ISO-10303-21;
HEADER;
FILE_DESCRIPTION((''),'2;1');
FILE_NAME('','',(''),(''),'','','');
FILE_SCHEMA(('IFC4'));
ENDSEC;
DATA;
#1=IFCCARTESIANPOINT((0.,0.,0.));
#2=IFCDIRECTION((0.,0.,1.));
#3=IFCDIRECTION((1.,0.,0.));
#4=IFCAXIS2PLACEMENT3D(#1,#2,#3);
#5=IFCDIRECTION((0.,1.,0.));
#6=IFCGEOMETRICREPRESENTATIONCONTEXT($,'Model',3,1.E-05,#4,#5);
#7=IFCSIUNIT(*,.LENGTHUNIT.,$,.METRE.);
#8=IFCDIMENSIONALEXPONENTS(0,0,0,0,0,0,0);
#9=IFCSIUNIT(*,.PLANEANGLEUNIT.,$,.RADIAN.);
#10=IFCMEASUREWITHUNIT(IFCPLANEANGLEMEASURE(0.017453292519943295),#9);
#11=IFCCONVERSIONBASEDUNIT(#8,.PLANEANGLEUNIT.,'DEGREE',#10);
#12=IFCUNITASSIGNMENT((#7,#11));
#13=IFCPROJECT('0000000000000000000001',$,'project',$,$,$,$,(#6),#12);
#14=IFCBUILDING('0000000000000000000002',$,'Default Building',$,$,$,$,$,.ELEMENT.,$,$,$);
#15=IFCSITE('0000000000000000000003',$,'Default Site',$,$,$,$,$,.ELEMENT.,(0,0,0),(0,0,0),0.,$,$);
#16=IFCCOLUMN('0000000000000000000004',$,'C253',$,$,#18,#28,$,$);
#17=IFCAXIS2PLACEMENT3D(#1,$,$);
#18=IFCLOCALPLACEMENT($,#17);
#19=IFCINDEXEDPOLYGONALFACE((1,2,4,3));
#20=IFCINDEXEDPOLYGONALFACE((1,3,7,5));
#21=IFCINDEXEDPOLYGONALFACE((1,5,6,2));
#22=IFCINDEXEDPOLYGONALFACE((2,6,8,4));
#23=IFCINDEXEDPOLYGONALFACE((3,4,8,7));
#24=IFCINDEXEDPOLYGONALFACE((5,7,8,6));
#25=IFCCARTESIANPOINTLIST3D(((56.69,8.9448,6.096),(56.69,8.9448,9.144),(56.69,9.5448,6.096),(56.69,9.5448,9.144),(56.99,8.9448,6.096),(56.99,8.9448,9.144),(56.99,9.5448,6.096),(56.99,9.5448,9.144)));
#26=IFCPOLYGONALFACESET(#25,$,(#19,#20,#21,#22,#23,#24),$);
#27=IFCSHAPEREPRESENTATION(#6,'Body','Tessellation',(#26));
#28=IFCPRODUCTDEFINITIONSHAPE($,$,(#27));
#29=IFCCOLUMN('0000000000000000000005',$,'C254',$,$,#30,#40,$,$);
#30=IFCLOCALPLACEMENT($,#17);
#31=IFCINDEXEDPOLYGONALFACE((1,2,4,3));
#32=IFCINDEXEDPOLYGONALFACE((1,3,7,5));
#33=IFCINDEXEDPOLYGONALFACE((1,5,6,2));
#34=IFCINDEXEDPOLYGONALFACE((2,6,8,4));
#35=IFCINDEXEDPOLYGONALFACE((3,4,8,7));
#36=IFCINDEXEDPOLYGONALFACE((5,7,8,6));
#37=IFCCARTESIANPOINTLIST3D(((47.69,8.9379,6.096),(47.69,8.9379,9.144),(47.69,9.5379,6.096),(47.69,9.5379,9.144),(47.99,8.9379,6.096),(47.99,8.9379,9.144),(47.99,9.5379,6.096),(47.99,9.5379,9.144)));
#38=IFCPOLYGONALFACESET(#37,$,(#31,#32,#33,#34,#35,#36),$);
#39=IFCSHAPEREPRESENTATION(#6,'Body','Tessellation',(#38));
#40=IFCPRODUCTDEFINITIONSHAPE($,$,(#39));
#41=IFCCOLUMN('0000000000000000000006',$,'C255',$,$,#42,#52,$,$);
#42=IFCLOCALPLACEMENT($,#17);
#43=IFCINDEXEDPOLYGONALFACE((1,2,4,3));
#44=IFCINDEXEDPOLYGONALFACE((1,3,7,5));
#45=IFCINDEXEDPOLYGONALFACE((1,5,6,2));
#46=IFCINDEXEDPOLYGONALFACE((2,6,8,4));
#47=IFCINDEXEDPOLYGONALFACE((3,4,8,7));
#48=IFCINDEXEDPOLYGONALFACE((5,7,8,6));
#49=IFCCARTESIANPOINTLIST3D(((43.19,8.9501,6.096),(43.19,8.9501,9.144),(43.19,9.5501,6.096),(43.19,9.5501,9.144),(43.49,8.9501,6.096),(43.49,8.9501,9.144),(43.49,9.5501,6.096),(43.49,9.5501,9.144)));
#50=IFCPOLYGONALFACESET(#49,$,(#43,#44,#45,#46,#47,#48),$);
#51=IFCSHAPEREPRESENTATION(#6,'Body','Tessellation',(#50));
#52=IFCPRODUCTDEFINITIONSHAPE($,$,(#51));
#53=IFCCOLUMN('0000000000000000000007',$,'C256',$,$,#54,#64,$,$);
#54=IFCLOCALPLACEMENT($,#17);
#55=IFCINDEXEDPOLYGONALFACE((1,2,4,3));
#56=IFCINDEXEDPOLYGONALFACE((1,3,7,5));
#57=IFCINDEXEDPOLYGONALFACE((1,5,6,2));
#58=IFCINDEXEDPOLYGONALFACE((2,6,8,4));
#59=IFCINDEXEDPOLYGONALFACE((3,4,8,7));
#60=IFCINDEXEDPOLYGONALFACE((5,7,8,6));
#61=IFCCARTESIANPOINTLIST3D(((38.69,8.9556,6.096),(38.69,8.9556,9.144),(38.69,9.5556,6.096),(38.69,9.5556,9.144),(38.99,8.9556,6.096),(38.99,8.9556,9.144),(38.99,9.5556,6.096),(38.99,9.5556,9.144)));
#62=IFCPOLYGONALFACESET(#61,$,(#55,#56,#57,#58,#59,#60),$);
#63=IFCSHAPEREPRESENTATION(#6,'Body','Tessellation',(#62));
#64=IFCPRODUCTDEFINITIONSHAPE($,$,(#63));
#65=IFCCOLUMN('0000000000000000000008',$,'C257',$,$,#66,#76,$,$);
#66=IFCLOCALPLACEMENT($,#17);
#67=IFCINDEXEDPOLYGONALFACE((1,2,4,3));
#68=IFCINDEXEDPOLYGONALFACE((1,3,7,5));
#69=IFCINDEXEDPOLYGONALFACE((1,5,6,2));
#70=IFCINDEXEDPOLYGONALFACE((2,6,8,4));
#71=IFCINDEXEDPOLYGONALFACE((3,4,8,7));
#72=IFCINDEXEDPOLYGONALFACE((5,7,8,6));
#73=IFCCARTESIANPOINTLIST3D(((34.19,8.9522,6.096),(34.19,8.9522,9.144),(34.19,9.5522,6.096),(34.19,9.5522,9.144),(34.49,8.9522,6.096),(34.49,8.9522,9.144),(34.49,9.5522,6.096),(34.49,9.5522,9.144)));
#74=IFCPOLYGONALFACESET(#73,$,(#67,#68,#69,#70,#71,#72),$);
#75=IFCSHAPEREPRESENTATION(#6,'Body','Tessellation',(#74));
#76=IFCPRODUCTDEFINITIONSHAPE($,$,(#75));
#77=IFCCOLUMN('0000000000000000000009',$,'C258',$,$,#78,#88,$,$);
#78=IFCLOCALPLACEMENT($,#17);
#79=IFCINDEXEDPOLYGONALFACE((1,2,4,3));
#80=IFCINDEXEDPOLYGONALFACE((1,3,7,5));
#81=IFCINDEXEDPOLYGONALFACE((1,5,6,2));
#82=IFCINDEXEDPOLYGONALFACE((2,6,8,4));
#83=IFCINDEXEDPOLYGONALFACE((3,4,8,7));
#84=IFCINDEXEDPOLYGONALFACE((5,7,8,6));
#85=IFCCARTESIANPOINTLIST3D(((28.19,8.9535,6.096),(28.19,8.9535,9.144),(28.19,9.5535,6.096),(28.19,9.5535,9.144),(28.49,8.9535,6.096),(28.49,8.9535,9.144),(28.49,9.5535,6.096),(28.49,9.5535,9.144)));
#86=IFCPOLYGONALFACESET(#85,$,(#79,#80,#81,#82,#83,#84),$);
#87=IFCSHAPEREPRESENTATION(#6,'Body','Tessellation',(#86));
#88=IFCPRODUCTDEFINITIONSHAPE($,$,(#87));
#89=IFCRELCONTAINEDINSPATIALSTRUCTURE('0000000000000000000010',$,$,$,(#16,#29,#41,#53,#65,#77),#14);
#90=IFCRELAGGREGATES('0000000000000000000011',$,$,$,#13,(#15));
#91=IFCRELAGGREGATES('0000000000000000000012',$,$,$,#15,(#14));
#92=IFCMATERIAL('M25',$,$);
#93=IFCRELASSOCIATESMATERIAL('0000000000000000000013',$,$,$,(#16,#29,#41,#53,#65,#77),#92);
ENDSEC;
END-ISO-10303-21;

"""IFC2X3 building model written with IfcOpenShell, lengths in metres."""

from ifc_helpers import new_model, entity, si_unit, converted_unit, direction, frame, frame_2d, origin_with_axes, place, context, project, spatial, rectangle, extrude, material, element, save


model = new_model("IFC2X3")

# Units and contexts
model_context = context("Model", 3, precision=1e-05, world=origin_with_axes(), true_north=direction((0.0, 1.0, 0.0)))
ifc_project = project(units=[si_unit("LENGTHUNIT", "METRE"), converted_unit("PLANEANGLEUNIT", "DEGREE", entity("IfcPlaneAngleMeasure", 0.017453292519943295), si_unit("PLANEANGLEUNIT", "RADIAN"), dimensions=[0, 0, 0, 0, 0, 0, 0])], contexts=[model_context])

# Site, building
site = spatial("IfcSite", under=ifc_project, Name="Default Site", CompositionType="ELEMENT", RefLatitude=(0, 0, 0), RefLongitude=(0, 0, 0), RefElevation=0.0)
building = spatial("IfcBuilding", under=site, Name="Default Building", CompositionType="ELEMENT")

# Columns
ifc_material = material(Name="M25")
placement = place(None, origin_with_axes())
element("IfcColumn", 1, at=placement, inside=building, material=ifc_material, Name="C253", context=model_context, shape_type="SweptSolid", body=[
    extrude(rectangle(XDim=0.3, YDim=0.6, at=frame_2d((0.0, 0.0), x_axis=(1.0, 0.0, 0.0))), frame((56.84, 9.2448, 6.096), z_axis=(0.0, 0.0, 1.0), x_axis=(1.0, 0.0, 0.0)), (0.0, 0.0, 1.0), 3.048),
])
element("IfcColumn", 2, at=placement, inside=building, material=ifc_material, Name="C254", context=model_context, shape_type="SweptSolid", body=[
    extrude(rectangle(XDim=0.3, YDim=0.6, at=frame_2d((0.0, 0.0), x_axis=(1.0, 0.0, 0.0))), frame((47.84, 9.2379, 6.096), z_axis=(0.0, 0.0, 1.0), x_axis=(1.0, 0.0, 0.0)), (0.0, 0.0, 1.0), 3.048),
])
element("IfcColumn", 3, at=placement, inside=building, material=ifc_material, Name="C255", context=model_context, shape_type="SweptSolid", body=[
    extrude(rectangle(XDim=0.3, YDim=0.6, at=frame_2d((0.0, 0.0), x_axis=(1.0, 0.0, 0.0))), frame((43.34, 9.2501, 6.096), z_axis=(0.0, 0.0, 1.0), x_axis=(1.0, 0.0, 0.0)), (0.0, 0.0, 1.0), 3.048),
])
element("IfcColumn", 4, at=placement, inside=building, material=ifc_material, Name="C256", context=model_context, shape_type="SweptSolid", body=[
    extrude(rectangle(XDim=0.3, YDim=0.6, at=frame_2d((0.0, 0.0), x_axis=(1.0, 0.0, 0.0))), frame((38.84, 9.2556, 6.096), z_axis=(0.0, 0.0, 1.0), x_axis=(1.0, 0.0, 0.0)), (0.0, 0.0, 1.0), 3.048),
])
element("IfcColumn", 5, at=placement, inside=building, material=ifc_material, Name="C257", context=model_context, shape_type="SweptSolid", body=[
    extrude(rectangle(XDim=0.3, YDim=0.6, at=frame_2d((0.0, 0.0), x_axis=(1.0, 0.0, 0.0))), frame((34.34, 9.2522, 6.096), z_axis=(0.0, 0.0, 1.0), x_axis=(1.0, 0.0, 0.0)), (0.0, 0.0, 1.0), 3.048),
])
element("IfcColumn", 6, at=placement, inside=building, material=ifc_material, Name="C258", context=model_context, shape_type="SweptSolid", body=[
    extrude(rectangle(XDim=0.3, YDim=0.6, at=frame_2d((0.0, 0.0), x_axis=(1.0, 0.0, 0.0))), frame((28.34, 9.2535, 6.096), z_axis=(0.0, 0.0, 1.0), x_axis=(1.0, 0.0, 0.0)), (0.0, 0.0, 1.0), 3.048),
])

save(model, "model.ifc")
